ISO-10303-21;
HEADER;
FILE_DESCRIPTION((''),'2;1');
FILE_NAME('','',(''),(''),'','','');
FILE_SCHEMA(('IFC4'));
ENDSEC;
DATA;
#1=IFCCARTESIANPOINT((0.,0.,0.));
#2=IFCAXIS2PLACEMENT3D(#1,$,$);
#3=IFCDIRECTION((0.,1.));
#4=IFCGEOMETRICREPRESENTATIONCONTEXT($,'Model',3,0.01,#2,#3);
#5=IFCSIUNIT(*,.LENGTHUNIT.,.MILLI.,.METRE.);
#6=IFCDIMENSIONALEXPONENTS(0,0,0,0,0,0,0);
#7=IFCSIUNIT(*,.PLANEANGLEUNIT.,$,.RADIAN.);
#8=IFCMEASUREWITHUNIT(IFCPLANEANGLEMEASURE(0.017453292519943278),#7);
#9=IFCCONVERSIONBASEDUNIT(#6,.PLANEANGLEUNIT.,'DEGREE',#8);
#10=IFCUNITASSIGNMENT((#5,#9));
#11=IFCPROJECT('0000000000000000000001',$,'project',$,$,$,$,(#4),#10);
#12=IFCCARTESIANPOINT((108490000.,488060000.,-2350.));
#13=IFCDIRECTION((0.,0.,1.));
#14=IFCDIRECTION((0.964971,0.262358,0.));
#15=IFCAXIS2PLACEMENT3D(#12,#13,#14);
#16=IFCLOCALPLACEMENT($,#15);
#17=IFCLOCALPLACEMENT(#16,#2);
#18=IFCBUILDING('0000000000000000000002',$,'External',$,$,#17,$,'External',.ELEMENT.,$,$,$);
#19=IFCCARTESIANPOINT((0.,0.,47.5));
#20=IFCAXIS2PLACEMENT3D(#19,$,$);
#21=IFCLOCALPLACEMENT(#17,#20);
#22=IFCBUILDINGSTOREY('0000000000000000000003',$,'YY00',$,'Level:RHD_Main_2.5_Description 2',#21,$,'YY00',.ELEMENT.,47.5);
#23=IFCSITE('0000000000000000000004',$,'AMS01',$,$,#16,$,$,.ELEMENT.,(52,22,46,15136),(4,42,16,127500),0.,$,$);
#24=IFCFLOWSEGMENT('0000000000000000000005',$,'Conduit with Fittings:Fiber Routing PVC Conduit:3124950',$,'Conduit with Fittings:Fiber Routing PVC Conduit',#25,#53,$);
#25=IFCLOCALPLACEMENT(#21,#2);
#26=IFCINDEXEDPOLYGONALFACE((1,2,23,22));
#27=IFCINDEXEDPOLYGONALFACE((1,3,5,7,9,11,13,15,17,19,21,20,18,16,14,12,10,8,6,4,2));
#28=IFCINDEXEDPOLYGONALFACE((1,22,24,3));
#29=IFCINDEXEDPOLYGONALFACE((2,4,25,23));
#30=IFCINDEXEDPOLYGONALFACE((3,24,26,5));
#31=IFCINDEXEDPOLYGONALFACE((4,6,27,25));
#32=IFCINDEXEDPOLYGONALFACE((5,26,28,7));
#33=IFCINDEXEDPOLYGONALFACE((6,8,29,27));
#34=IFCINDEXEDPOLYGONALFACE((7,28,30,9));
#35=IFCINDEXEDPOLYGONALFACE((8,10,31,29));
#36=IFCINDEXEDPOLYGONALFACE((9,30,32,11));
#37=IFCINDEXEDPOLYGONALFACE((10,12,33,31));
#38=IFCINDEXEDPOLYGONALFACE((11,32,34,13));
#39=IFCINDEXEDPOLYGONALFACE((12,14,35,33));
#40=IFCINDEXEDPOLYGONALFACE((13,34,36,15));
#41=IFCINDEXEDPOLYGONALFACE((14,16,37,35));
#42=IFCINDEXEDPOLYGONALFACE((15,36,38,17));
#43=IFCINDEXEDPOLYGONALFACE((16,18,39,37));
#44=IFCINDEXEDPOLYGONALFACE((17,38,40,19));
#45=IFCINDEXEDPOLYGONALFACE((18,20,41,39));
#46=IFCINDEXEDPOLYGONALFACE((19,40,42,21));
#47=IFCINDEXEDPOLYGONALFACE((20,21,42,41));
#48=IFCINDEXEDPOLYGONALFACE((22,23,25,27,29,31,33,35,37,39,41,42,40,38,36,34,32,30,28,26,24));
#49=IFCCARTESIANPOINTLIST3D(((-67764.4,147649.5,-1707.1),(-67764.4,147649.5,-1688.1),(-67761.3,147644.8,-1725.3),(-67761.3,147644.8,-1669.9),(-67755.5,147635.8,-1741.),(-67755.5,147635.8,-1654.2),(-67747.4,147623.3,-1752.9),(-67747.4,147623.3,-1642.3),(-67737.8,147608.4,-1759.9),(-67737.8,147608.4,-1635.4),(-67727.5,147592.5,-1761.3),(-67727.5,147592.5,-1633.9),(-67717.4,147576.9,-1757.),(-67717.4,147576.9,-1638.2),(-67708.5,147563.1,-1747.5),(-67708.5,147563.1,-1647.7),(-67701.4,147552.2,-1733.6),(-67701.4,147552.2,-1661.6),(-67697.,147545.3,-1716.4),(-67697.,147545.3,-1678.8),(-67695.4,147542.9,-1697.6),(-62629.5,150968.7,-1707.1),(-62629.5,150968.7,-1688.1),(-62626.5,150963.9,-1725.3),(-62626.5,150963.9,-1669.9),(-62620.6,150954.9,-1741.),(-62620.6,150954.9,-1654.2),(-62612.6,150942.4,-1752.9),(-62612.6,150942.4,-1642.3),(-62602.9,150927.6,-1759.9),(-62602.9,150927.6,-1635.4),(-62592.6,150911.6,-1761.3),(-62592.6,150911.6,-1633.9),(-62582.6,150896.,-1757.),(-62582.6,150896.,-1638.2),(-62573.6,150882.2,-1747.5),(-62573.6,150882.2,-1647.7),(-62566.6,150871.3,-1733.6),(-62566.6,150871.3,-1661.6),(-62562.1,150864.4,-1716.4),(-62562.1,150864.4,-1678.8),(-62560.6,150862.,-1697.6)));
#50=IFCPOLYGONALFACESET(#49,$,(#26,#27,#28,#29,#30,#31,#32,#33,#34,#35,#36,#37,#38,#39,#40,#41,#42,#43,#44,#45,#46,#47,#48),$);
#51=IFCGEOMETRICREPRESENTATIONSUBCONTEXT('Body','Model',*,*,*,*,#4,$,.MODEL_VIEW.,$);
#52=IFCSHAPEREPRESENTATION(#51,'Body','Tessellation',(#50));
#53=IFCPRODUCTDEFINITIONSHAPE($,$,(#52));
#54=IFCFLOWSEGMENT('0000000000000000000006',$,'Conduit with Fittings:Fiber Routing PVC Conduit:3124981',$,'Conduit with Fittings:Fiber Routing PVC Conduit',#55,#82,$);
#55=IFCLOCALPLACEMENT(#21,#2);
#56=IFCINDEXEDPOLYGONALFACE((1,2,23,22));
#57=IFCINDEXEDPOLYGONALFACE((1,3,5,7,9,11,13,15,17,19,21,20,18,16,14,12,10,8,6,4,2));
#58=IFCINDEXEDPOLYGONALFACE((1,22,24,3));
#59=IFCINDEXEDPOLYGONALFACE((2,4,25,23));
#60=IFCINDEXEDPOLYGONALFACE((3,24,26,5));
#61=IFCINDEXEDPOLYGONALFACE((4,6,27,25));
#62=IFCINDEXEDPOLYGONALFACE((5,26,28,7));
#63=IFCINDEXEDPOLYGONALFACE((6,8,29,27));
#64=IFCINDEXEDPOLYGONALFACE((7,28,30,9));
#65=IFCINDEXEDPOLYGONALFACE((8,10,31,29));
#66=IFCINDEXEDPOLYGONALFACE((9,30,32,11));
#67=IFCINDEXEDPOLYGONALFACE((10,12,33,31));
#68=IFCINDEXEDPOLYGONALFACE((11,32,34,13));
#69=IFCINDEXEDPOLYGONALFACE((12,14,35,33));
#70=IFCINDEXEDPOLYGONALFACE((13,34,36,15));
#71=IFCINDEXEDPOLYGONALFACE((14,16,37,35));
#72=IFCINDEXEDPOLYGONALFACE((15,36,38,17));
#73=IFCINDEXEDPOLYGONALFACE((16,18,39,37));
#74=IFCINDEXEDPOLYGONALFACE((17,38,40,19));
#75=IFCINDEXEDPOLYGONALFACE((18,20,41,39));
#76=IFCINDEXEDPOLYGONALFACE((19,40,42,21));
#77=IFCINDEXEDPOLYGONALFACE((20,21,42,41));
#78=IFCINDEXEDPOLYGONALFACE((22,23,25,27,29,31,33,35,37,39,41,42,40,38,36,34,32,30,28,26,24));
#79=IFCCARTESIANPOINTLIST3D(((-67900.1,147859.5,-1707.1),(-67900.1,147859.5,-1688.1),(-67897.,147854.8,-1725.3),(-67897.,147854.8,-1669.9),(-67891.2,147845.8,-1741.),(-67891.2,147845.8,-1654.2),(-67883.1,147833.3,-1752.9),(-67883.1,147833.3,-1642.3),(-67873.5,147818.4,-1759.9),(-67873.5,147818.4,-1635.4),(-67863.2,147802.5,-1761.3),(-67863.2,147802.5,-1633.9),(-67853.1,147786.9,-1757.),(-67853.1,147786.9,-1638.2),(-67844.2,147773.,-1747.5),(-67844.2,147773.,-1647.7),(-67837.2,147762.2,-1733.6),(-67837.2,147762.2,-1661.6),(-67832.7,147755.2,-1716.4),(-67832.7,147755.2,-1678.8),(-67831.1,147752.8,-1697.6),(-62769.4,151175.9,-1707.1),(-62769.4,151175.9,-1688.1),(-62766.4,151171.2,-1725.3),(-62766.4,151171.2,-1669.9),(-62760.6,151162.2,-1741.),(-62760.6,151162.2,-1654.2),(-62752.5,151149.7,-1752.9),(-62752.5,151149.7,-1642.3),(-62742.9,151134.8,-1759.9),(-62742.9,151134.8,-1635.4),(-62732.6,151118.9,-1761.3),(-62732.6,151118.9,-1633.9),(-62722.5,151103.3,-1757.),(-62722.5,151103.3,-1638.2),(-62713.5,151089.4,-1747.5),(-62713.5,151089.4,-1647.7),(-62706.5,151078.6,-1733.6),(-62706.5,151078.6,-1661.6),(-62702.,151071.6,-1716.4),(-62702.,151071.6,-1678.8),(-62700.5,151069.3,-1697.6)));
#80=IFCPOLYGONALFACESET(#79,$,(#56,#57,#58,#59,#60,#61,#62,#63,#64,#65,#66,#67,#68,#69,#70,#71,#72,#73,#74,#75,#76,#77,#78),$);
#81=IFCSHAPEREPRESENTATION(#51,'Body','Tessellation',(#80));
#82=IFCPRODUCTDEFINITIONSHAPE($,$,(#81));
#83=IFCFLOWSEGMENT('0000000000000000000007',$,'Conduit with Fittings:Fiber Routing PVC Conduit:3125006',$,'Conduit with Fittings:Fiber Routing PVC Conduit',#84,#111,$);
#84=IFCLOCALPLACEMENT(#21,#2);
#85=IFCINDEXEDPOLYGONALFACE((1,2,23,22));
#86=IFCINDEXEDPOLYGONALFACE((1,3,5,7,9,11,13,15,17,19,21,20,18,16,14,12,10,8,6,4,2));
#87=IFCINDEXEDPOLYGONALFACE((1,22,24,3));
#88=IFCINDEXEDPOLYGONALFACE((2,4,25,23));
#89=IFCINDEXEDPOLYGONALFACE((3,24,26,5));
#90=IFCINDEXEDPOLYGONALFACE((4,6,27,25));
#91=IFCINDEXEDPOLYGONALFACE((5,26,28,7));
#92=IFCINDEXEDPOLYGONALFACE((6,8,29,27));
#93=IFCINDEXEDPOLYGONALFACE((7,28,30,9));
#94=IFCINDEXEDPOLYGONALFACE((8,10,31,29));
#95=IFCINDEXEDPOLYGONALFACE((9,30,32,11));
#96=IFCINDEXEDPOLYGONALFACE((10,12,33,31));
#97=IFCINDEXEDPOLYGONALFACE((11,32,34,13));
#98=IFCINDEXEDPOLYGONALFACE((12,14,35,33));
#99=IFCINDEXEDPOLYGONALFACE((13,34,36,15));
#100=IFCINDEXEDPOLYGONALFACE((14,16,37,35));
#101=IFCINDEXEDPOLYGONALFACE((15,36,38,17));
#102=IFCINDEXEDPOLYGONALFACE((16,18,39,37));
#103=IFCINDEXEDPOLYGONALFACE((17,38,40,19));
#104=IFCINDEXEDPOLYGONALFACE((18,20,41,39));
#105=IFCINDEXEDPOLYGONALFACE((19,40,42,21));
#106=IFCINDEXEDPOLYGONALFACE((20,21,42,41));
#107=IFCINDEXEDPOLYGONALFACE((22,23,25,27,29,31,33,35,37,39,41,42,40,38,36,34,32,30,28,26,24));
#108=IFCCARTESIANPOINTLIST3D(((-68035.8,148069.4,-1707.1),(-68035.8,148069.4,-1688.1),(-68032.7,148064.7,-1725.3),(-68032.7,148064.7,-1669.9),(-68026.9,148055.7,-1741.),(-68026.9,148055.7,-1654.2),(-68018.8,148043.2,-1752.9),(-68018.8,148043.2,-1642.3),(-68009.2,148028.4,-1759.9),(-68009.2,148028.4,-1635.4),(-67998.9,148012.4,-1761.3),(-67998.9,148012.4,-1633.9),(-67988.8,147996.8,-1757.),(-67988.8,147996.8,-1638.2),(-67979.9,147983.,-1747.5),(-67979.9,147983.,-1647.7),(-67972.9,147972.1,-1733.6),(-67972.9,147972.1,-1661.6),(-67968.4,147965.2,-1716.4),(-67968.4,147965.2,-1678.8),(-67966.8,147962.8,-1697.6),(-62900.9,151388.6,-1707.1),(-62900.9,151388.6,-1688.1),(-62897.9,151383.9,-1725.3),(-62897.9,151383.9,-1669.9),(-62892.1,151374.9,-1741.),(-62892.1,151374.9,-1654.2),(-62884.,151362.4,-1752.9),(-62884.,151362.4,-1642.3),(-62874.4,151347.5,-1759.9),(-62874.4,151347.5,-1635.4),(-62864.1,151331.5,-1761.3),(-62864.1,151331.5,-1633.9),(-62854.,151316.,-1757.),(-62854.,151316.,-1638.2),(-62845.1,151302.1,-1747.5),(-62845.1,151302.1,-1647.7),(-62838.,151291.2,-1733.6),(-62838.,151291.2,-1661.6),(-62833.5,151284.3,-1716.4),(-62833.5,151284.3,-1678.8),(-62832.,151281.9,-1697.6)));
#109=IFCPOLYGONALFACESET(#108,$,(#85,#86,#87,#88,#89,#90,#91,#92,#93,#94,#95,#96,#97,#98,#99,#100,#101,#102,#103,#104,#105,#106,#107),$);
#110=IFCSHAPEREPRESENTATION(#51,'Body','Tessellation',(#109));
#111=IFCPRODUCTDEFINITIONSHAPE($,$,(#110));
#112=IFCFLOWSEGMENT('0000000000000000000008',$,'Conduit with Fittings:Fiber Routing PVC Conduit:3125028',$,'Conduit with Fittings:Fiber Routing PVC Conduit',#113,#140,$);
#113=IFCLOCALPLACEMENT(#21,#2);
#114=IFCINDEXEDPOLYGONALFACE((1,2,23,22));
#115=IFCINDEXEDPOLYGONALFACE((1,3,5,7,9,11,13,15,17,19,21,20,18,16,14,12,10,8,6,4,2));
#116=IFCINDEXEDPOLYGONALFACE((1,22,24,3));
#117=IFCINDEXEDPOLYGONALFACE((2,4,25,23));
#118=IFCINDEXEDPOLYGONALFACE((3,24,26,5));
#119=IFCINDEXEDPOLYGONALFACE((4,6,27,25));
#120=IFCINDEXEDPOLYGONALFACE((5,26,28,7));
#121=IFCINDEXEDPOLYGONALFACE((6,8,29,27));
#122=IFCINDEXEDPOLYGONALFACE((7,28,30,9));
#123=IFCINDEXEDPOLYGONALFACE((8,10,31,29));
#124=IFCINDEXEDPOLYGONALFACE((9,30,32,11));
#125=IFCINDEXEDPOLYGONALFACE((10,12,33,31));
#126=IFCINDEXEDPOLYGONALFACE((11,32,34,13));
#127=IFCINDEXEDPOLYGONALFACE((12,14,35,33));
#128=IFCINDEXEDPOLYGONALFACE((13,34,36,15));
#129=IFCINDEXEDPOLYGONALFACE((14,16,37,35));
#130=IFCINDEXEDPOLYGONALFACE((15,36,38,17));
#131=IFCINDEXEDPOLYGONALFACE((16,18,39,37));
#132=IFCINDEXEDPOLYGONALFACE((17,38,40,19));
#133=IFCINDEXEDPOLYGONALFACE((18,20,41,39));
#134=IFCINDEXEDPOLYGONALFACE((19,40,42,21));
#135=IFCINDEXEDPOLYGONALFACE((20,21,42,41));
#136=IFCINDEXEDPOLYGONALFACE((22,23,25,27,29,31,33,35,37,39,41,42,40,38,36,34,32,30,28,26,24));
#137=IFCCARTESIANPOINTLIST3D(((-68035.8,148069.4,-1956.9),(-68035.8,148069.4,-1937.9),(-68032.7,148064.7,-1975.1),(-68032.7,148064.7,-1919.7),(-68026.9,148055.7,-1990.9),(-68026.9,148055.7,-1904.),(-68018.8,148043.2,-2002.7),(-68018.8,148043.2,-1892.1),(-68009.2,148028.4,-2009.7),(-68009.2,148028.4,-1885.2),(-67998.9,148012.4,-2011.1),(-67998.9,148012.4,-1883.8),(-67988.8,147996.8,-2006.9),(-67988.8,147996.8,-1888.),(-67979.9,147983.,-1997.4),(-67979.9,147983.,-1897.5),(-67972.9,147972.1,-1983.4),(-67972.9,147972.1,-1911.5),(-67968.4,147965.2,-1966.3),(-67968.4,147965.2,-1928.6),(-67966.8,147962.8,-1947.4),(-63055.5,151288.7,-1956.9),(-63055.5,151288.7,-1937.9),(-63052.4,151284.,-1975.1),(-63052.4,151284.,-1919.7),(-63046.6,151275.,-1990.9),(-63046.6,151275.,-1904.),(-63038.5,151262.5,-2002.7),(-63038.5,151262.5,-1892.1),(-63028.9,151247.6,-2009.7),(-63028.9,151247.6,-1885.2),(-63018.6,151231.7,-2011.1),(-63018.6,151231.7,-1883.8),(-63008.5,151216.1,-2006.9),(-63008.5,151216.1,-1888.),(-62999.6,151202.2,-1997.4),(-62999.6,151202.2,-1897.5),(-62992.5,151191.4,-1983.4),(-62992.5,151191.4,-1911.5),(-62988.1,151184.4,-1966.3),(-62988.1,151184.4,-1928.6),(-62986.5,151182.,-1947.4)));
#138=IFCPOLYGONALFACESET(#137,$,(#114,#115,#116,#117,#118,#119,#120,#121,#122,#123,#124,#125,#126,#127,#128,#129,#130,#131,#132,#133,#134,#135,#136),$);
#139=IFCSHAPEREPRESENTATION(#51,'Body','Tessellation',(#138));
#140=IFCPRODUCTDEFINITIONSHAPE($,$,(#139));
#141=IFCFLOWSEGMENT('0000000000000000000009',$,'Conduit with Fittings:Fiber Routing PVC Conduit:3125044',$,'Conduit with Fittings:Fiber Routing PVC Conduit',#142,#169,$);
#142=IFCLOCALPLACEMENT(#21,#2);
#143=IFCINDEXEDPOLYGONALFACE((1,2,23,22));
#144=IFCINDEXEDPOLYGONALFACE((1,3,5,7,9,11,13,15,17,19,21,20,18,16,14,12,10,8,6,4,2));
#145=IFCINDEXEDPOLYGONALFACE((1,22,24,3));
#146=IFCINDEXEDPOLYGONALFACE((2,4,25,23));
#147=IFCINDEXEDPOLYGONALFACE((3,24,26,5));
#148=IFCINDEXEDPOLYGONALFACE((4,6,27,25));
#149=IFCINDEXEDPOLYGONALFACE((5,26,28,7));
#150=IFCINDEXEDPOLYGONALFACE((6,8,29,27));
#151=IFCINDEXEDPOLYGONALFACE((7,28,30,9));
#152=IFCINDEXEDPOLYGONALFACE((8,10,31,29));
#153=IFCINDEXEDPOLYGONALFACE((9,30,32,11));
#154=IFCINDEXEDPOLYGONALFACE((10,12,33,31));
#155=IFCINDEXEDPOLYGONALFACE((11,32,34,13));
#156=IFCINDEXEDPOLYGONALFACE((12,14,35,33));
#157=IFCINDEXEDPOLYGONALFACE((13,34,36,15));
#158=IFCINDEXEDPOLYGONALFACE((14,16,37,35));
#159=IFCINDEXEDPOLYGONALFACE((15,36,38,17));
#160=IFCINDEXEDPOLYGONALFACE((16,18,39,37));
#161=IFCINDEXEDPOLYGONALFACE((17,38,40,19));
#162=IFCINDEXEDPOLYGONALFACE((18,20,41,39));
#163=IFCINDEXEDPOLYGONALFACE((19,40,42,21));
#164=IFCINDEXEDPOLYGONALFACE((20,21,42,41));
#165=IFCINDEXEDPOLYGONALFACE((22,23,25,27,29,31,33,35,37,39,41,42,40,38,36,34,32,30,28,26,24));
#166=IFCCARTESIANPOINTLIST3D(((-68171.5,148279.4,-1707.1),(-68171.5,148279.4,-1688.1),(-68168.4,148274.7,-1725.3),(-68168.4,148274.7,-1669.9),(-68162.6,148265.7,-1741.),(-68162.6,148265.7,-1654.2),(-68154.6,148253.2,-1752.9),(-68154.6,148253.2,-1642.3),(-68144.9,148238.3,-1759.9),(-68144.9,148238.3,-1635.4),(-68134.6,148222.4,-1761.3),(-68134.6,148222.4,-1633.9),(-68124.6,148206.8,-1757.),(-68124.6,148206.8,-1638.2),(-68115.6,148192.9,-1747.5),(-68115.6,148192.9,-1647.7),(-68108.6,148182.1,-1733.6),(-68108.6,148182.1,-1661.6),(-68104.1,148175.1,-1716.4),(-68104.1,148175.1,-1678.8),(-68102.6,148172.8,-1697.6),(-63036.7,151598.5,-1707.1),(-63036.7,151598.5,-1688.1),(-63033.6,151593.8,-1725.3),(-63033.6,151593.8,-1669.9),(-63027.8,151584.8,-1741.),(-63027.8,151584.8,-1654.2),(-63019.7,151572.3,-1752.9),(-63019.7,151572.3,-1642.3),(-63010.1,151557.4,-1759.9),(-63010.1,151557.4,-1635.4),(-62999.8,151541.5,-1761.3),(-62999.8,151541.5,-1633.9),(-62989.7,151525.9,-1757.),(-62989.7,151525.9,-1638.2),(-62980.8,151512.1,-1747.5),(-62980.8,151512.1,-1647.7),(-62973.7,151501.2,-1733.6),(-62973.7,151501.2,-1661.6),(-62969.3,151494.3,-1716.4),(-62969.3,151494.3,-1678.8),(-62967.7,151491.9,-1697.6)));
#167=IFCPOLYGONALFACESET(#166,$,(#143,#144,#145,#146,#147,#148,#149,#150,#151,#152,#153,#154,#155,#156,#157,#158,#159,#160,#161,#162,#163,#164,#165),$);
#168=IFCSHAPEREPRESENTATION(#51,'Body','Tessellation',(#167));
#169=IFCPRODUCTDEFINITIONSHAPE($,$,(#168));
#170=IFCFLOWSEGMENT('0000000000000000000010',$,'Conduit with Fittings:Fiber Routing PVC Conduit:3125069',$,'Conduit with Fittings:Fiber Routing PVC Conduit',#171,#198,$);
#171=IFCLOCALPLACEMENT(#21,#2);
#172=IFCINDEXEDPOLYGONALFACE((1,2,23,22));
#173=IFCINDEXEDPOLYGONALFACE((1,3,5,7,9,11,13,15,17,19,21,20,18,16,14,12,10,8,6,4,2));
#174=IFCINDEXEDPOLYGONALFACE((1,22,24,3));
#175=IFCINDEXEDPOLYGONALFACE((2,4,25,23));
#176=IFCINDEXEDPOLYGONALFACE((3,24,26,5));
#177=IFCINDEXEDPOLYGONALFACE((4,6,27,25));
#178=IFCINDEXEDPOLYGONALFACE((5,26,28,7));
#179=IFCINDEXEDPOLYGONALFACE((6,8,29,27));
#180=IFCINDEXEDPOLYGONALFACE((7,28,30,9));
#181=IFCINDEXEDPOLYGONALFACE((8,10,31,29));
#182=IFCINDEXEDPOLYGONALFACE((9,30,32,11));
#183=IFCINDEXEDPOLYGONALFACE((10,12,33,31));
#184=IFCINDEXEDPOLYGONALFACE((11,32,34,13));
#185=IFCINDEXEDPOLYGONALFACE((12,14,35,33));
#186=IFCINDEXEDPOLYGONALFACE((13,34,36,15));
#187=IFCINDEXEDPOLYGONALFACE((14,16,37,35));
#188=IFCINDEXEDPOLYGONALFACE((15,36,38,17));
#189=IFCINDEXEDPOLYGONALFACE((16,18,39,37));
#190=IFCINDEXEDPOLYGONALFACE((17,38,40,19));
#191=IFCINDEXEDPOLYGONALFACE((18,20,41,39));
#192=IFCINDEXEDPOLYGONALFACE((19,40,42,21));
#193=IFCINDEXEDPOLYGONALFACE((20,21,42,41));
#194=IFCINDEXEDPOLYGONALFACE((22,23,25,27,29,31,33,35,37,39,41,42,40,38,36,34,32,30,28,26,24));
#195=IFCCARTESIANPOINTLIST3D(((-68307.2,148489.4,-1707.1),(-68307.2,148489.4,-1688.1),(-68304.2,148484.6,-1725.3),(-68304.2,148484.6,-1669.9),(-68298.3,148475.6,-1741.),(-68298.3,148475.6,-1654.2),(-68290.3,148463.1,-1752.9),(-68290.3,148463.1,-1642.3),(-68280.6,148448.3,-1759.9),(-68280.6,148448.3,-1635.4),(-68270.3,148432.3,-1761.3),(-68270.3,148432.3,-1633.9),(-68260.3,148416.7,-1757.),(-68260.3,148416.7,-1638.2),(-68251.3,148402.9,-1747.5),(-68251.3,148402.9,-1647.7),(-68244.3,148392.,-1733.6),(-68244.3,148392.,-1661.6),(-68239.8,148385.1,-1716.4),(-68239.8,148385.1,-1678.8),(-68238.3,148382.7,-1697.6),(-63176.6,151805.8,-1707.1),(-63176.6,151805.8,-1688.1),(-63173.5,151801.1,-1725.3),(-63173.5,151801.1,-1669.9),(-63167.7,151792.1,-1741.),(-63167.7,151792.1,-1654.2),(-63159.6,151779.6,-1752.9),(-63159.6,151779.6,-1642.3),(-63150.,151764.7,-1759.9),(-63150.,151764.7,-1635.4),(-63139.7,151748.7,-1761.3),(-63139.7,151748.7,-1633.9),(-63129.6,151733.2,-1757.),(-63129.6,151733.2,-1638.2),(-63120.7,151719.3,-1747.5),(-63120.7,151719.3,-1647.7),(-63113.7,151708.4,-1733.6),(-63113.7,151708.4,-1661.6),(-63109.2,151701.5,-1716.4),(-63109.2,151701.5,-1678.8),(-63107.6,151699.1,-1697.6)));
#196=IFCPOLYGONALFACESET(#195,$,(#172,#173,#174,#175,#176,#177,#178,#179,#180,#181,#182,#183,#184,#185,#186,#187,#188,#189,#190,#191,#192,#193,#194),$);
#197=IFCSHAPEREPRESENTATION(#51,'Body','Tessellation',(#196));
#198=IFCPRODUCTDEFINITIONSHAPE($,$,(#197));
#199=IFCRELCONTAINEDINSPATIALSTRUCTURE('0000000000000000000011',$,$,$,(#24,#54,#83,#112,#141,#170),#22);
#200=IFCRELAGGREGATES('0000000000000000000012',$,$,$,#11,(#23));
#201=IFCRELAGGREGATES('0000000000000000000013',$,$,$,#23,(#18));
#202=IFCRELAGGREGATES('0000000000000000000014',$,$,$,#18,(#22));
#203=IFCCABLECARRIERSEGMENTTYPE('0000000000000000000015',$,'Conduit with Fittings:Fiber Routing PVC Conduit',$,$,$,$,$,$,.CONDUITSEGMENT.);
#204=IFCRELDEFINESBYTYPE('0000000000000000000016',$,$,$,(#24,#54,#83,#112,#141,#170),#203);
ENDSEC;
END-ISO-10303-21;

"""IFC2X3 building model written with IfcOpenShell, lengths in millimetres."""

from ifc_helpers import new_model, entity, si_unit, converted_unit, direction, frame, frame_2d, origin, origin_2d_with_axis, place, context, subcontext, project, spatial, circle, extrude, type_object, element, save


model = new_model("IFC2X3")

# Units and contexts
model_context = context("Model", 3, precision=0.01, world=origin(), true_north=direction((0.0, 1.0)))
body_context = subcontext(model_context, "Body", "Model", "MODEL_VIEW")
ifc_project = project(units=[si_unit("LENGTHUNIT", "METRE", prefix="MILLI"), converted_unit("PLANEANGLEUNIT", "DEGREE", entity("IfcPlaneAngleMeasure", 0.017453292519943278), si_unit("PLANEANGLEUNIT", "RADIAN"), dimensions=[0, 0, 0, 0, 0, 0, 0])], contexts=[model_context])

# Site, building, storey
site_placement = place(None, frame((108490000.0, 488060000.0, -2350.0), z_axis=(0.0, 0.0, 1.0), x_axis=(0.964971, 0.262358, 0.0)))
site = spatial("IfcSite", under=ifc_project, at=site_placement, Name="AMS01", CompositionType="ELEMENT", RefLatitude=(52, 22, 46, 15136), RefLongitude=(4, 42, 16, 127500), RefElevation=0.0)
building_placement = place(site_placement, origin())
building = spatial("IfcBuilding", under=site, at=building_placement, Name="External", LongName="External", CompositionType="ELEMENT")
storey_placement = place(building_placement, frame((0.0, 0.0, 47.5)))
storey = spatial("IfcBuildingStorey", under=building, at=storey_placement, Name="YY00", ObjectType="Level:RHD_Main_2.5_Description 2", LongName="YY00", CompositionType="ELEMENT", Elevation=47.5)

# Flow segments
cable_carrier_segment_type = type_object("IfcCableCarrierSegmentType", Name="Conduit with Fittings:Fiber Routing PVC Conduit", PredefinedType="CONDUITSEGMENT")
flow_segment_1_placement = place(storey_placement, origin())
element("IfcFlowSegment", 1, at=flow_segment_1_placement, inside=storey, type_object=cable_carrier_segment_type, Name="Conduit with Fittings:Fiber Routing PVC Conduit:3124950", ObjectType="Conduit with Fittings:Fiber Routing PVC Conduit", context=body_context, shape_type="SweptSolid", body=[
    extrude(circle(Radius=63.9, at=origin_2d_with_axis()), frame((-67730.1, 147596.5, -1697.6), z_axis=(0.839826, 0.542856, 0.0), x_axis=(0.542856, -0.839826, 0.0)), (0.0, 0.0, 1.0), 6114.2),
])
flow_segment_2_placement = place(storey_placement, origin())
element("IfcFlowSegment", 2, at=flow_segment_2_placement, inside=storey, type_object=cable_carrier_segment_type, Name="Conduit with Fittings:Fiber Routing PVC Conduit:3124981", ObjectType="Conduit with Fittings:Fiber Routing PVC Conduit", context=body_context, shape_type="SweptSolid", body=[
    extrude(circle(Radius=63.9, at=origin_2d_with_axis()), frame((-67865.8, 147806.5, -1697.6), z_axis=(0.839826, 0.542856, 0.0), x_axis=(0.542856, -0.839826, 0.0)), (0.0, 0.0, 1.0), 6109.2),
])
flow_segment_3_placement = place(storey_placement, origin())
element("IfcFlowSegment", 3, at=flow_segment_3_placement, inside=storey, type_object=cable_carrier_segment_type, Name="Conduit with Fittings:Fiber Routing PVC Conduit:3125006", ObjectType="Conduit with Fittings:Fiber Routing PVC Conduit", context=body_context, shape_type="SweptSolid", body=[
    extrude(circle(Radius=63.9, at=origin_2d_with_axis()), frame((-68001.5, 148016.4, -1697.6), z_axis=(0.839826, 0.542856, 0.0), x_axis=(0.542856, -0.839826, 0.0)), (0.0, 0.0, 1.0), 6114.2),
])
flow_segment_4_placement = place(storey_placement, origin())
element("IfcFlowSegment", 4, at=flow_segment_4_placement, inside=storey, type_object=cable_carrier_segment_type, Name="Conduit with Fittings:Fiber Routing PVC Conduit:3125028", ObjectType="Conduit with Fittings:Fiber Routing PVC Conduit", context=body_context, shape_type="SweptSolid", body=[
    extrude(circle(Radius=63.9, at=origin_2d_with_axis()), frame((-68001.5, 148016.4, -1947.4), z_axis=(0.839826, 0.542856, 0.0), x_axis=(0.542856, -0.839826, 0.0)), (0.0, 0.0, 1.0), 5930.2),
])
flow_segment_5_placement = place(storey_placement, origin())
element("IfcFlowSegment", 5, at=flow_segment_5_placement, inside=storey, type_object=cable_carrier_segment_type, Name="Conduit with Fittings:Fiber Routing PVC Conduit:3125044", ObjectType="Conduit with Fittings:Fiber Routing PVC Conduit", context=body_context, shape_type="SweptSolid", body=[
    extrude(circle(Radius=63.9, at=frame_2d((0.0, 0.0), x_axis=(1.0, 0.0))), frame((-68137.2, 148226.4, -1697.6), z_axis=(0.839826, 0.542856, 0.0), x_axis=(0.542856, -0.839826, 0.0)), (0.0, 0.0, 1.0), 6114.2),
])
flow_segment_6_placement = place(storey_placement, origin())
element("IfcFlowSegment", 6, at=flow_segment_6_placement, inside=storey, type_object=cable_carrier_segment_type, Name="Conduit with Fittings:Fiber Routing PVC Conduit:3125069", ObjectType="Conduit with Fittings:Fiber Routing PVC Conduit", context=body_context, shape_type="SweptSolid", body=[
    extrude(circle(Radius=63.9, at=origin_2d_with_axis()), frame((-68272.9, 148436.3, -1697.6), z_axis=(0.839826, 0.542856, 0.0), x_axis=(0.542856, -0.839826, 0.0)), (0.0, 0.0, 1.0), 6109.2),
])

save(model, "model.ifc")
